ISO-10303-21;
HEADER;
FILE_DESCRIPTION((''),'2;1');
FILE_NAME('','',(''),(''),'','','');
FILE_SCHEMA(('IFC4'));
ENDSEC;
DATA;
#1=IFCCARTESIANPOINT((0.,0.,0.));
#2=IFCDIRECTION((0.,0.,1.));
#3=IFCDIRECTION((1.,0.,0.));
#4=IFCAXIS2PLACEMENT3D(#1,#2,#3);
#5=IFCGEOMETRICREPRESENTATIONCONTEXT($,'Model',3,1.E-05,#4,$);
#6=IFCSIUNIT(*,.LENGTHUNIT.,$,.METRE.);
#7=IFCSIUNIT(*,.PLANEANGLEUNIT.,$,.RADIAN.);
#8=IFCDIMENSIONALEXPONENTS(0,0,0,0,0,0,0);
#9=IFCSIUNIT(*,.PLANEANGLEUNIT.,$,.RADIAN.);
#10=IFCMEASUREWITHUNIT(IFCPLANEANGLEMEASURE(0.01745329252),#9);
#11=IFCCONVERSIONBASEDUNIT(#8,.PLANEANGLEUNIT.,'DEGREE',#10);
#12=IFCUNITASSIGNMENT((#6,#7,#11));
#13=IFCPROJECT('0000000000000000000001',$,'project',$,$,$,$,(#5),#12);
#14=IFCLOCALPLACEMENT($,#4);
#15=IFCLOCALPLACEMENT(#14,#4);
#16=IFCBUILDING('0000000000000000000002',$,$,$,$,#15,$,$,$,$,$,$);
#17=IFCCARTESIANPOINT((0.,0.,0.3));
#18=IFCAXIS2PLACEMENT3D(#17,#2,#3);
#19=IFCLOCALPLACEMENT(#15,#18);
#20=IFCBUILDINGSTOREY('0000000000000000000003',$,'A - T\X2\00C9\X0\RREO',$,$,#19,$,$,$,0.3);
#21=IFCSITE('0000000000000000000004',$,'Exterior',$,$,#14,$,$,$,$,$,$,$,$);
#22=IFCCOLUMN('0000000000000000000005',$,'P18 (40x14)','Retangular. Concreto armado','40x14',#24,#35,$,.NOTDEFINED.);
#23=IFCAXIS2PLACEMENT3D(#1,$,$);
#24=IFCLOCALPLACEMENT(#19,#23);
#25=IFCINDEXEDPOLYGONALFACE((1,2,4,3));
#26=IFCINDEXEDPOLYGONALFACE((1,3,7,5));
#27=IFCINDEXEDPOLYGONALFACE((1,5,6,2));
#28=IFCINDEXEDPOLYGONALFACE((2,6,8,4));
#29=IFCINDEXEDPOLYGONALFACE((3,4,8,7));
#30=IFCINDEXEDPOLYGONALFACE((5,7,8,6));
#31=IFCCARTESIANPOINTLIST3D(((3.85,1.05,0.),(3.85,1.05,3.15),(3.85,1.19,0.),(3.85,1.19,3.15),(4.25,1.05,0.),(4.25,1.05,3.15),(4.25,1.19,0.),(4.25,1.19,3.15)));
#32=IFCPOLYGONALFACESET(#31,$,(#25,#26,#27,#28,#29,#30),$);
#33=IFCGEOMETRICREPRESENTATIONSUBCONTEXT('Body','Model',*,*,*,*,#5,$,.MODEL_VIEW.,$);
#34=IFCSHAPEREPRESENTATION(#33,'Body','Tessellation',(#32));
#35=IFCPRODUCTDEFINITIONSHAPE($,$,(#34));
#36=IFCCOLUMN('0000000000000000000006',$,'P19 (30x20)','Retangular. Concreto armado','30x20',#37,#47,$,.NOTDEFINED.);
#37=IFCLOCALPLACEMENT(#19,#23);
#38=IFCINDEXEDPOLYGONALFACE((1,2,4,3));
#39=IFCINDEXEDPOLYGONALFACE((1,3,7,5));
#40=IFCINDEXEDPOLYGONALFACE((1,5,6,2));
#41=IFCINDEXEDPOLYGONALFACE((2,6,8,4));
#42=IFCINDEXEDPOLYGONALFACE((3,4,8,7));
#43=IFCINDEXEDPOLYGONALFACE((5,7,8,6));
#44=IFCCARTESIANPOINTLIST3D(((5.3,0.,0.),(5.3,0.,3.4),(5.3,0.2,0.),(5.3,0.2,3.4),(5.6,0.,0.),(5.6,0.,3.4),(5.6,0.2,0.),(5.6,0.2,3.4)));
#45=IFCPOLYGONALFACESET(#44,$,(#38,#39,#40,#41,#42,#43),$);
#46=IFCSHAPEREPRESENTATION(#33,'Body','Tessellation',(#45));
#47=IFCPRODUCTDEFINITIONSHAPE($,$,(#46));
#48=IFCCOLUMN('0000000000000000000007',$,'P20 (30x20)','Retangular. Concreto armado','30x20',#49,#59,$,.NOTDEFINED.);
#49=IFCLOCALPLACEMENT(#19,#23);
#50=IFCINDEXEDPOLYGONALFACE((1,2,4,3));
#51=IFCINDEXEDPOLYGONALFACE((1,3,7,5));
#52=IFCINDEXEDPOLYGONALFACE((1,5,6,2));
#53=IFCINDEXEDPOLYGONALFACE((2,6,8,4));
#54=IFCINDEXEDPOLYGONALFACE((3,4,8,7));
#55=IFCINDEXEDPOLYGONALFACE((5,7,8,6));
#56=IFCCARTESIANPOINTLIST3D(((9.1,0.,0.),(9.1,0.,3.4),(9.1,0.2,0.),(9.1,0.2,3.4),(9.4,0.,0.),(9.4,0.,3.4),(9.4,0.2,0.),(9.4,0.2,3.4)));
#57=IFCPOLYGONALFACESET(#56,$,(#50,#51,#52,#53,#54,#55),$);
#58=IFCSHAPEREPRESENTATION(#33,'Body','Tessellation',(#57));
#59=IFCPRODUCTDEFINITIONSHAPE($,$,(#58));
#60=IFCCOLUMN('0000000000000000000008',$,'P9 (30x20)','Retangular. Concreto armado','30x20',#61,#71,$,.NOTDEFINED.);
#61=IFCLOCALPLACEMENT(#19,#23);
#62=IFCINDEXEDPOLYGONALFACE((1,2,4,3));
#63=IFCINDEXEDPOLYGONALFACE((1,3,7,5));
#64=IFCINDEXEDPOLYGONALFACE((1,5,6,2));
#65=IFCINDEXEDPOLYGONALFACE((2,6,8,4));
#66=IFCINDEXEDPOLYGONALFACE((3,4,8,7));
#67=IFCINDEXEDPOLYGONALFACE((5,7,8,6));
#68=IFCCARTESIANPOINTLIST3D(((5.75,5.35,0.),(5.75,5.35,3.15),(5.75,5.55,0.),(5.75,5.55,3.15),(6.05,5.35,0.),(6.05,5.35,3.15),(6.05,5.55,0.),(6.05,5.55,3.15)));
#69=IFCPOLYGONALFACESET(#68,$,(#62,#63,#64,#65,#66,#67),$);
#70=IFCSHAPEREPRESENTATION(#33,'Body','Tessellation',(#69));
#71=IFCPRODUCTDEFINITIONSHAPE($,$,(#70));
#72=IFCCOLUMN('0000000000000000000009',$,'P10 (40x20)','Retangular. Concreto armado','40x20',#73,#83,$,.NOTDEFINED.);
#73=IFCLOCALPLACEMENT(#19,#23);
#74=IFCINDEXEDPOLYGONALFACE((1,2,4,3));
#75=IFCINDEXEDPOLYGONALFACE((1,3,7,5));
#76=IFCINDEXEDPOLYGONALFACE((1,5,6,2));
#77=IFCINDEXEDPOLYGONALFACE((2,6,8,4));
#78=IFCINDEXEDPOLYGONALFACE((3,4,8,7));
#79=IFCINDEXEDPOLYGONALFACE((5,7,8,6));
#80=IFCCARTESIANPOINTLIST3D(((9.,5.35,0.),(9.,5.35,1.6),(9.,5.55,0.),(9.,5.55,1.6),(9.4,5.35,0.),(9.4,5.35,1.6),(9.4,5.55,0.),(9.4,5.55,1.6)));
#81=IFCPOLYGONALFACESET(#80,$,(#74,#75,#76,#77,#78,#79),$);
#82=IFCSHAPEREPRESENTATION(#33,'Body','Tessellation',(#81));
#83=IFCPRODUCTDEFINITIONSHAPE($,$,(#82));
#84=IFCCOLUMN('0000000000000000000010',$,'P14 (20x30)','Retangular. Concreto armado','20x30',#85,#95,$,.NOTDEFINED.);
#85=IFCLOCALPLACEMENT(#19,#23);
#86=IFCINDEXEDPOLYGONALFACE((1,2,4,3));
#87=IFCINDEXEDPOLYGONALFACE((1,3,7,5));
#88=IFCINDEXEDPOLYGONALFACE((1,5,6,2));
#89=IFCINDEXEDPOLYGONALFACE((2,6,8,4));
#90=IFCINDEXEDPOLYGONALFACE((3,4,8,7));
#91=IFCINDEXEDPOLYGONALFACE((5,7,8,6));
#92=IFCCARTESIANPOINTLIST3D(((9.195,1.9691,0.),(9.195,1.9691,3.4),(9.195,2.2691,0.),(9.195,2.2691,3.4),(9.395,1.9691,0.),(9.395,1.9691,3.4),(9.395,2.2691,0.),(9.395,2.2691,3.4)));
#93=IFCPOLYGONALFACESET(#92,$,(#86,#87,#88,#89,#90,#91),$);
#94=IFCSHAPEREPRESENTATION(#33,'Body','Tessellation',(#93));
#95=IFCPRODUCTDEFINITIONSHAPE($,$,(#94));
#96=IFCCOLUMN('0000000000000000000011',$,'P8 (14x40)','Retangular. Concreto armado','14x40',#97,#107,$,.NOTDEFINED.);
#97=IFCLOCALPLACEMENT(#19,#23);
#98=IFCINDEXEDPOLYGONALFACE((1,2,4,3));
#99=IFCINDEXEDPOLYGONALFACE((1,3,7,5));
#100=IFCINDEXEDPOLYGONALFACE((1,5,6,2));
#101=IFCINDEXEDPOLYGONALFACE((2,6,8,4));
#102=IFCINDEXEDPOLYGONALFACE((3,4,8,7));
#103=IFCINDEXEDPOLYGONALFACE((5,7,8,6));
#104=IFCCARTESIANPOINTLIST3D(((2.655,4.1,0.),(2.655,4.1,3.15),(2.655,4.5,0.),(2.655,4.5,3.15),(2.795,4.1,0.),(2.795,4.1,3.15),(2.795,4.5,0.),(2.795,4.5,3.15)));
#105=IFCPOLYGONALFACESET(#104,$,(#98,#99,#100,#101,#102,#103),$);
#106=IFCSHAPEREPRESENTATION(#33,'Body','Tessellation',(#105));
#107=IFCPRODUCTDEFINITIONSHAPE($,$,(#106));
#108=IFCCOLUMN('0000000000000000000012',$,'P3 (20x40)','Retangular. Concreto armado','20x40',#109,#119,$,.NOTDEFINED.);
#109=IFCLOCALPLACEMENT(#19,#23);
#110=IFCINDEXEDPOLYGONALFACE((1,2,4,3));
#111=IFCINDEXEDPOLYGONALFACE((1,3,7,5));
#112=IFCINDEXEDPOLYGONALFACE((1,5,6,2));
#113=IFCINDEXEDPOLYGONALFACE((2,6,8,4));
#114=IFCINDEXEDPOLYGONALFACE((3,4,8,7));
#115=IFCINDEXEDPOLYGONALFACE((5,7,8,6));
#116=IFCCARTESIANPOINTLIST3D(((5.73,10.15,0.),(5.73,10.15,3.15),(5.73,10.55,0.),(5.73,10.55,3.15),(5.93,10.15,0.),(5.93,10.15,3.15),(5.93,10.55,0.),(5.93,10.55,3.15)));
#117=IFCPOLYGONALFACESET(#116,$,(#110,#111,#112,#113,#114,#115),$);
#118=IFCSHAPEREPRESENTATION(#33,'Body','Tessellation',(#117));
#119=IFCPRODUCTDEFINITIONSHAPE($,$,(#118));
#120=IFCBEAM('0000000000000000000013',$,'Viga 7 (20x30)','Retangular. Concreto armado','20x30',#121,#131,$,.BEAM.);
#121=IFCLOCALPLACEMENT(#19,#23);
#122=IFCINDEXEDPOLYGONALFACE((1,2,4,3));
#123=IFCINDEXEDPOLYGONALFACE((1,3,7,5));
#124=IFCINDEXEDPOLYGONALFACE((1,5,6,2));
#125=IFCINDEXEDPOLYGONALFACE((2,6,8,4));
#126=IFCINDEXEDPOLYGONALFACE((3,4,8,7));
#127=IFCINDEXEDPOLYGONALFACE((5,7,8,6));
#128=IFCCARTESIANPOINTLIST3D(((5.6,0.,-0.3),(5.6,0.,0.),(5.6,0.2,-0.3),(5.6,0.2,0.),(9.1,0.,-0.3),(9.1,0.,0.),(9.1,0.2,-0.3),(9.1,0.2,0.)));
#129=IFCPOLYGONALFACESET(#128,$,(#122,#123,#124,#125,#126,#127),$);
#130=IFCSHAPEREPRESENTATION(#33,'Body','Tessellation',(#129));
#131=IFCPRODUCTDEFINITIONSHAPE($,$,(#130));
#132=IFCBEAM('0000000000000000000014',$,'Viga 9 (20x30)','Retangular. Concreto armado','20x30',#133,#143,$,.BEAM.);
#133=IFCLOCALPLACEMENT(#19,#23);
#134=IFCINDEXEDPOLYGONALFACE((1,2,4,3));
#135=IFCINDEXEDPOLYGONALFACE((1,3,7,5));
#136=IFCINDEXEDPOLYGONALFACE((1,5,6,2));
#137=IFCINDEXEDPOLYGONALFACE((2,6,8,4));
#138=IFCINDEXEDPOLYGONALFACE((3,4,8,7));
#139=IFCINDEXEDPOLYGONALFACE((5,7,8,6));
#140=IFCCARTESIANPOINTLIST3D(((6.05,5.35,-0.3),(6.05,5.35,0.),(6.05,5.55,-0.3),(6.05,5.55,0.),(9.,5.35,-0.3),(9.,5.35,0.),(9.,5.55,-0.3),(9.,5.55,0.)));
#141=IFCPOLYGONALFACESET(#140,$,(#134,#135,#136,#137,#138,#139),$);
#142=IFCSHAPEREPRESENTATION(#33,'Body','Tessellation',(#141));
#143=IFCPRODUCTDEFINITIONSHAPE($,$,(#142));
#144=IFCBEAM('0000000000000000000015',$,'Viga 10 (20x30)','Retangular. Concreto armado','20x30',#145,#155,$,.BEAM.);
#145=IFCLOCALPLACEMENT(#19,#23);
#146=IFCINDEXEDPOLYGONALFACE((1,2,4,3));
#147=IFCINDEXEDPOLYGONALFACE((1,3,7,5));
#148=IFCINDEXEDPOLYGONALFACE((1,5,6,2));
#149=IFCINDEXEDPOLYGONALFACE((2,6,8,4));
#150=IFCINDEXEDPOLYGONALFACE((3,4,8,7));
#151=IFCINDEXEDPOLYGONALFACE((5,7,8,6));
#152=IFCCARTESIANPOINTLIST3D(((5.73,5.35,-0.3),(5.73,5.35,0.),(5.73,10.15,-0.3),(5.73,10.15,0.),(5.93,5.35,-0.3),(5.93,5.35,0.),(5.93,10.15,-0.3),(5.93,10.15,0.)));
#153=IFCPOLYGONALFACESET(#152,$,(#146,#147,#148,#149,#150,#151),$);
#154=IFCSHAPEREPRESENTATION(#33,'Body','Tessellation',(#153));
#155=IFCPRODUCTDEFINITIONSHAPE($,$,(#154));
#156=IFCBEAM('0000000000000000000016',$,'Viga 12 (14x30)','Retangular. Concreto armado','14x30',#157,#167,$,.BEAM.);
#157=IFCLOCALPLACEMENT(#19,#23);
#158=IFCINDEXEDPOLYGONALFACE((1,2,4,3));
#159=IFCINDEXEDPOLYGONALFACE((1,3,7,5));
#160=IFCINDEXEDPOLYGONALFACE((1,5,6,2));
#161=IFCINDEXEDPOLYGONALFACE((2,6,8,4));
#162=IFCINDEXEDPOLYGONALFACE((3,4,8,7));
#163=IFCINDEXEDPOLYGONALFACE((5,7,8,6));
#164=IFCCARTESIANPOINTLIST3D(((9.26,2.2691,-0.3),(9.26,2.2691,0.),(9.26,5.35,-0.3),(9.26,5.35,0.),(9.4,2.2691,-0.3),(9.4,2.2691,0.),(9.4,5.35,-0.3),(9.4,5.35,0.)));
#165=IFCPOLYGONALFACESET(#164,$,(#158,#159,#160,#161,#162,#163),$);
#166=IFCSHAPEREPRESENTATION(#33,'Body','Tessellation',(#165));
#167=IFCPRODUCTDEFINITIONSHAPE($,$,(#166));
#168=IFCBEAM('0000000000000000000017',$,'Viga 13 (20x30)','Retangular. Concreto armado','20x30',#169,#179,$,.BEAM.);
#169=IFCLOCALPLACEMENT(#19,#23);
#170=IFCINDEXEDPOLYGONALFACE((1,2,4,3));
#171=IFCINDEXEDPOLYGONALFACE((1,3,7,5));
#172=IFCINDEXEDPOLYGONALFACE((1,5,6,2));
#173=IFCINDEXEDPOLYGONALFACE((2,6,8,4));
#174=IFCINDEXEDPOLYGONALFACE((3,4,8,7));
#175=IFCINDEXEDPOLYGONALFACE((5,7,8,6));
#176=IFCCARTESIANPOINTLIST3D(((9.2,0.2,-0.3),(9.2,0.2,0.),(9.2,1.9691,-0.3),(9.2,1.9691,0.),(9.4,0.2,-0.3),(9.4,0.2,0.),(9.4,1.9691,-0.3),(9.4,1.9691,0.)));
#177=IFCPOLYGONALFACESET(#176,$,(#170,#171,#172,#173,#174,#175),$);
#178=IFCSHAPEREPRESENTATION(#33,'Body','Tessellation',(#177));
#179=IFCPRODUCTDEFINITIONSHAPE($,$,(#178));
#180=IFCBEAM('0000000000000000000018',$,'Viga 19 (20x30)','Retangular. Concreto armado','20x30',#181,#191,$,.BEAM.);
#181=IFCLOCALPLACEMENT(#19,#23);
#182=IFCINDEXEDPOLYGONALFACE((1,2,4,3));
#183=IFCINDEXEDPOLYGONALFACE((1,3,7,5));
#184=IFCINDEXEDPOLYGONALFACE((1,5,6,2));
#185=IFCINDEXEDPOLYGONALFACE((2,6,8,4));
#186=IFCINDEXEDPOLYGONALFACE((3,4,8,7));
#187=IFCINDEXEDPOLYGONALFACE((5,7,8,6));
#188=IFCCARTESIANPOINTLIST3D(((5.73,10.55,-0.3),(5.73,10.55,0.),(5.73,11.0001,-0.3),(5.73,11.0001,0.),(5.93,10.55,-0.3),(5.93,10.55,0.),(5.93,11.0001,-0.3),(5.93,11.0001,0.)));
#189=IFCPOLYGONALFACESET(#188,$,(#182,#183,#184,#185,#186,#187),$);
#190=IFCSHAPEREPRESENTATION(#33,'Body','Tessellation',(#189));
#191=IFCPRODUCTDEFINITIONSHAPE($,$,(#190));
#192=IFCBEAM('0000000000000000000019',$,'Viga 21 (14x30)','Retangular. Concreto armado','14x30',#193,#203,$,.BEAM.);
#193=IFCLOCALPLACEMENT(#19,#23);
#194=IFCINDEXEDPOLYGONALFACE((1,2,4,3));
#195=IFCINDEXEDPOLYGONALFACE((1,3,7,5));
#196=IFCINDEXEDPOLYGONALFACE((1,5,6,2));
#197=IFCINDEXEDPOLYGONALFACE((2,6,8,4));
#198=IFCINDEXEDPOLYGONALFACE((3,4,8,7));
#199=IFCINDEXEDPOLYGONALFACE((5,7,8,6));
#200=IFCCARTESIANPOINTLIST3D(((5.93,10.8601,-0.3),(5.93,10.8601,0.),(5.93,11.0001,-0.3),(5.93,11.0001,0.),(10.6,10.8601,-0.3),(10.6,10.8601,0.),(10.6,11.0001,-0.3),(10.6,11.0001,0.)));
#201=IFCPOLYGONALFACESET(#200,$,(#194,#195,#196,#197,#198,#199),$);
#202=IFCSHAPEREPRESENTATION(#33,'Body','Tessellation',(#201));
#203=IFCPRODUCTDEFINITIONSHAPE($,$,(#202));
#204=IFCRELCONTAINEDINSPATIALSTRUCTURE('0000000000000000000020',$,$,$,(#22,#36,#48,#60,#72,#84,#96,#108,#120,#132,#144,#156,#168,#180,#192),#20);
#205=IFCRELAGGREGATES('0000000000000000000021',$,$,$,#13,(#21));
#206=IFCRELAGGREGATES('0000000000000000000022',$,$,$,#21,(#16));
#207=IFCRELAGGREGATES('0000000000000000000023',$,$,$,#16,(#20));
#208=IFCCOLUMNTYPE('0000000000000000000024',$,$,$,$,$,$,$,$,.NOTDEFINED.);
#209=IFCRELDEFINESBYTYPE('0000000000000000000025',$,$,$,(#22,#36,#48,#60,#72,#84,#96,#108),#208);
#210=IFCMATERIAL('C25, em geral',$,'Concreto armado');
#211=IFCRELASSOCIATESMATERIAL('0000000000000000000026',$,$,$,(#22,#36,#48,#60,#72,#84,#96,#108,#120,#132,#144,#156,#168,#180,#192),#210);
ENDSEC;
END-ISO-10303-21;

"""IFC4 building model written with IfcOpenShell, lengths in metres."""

from ifc_helpers import new_model, entity, si_unit, converted_unit, frame, frame_2d, origin_with_axes, origin_2d_with_axis, place, context, subcontext, project, spatial, rectangle, extrude, material, type_object, element, save


model = new_model("IFC4")

# Units and contexts
model_context = context("Model", 3, precision=1e-05, world=origin_with_axes())
body_context = subcontext(model_context, "Body", "Model", "MODEL_VIEW")
ifc_project = project(units=[si_unit("LENGTHUNIT", "METRE"), si_unit("PLANEANGLEUNIT", "RADIAN"), converted_unit("PLANEANGLEUNIT", "DEGREE", entity("IfcPlaneAngleMeasure", 0.01745329252), si_unit("PLANEANGLEUNIT", "RADIAN"), dimensions=[0, 0, 0, 0, 0, 0, 0])], contexts=[model_context])

# Site, building, storey
site_placement = place(None, origin_with_axes())
site = spatial("IfcSite", under=ifc_project, at=site_placement, Name="Exterior")
building_placement = place(site_placement, origin_with_axes())
building = spatial("IfcBuilding", under=site, at=building_placement)
storey_placement = place(building_placement, frame((0.0, 0.0, 0.3), z_axis=(0.0, 0.0, 1.0), x_axis=(1.0, 0.0, 0.0)))
storey = spatial("IfcBuildingStorey", under=building, at=storey_placement, Name="A - TÉRREO", Elevation=0.3)

# Columns
ifc_material = material(Name="C25, em geral", Category="Concreto armado")
column_type = type_object("IfcColumnType", PredefinedType="NOTDEFINED")
column_1_placement = place(storey_placement, frame((4.25, 1.12, 0.0), z_axis=(0.0, 0.0, 1.0), x_axis=(1.0, 0.0, 0.0)))
element("IfcColumn", 1, at=column_1_placement, inside=storey, type_object=column_type, material=ifc_material, Name="P18 (40x14)", Description="Retangular. Concreto armado", ObjectType="40x14", PredefinedType="NOTDEFINED", context=body_context, shape_type="SweptSolid", body=[
    extrude(rectangle(XDim=0.4, YDim=0.14, at=frame_2d((-0.2, 0.0), x_axis=(1.0, 0.0))), origin_with_axes(), (0.0, 0.0, 1.0), 3.15),
])
for number, where, z_axis, x_axis, name in (
    (2, (5.45, 0.1, 0.0), (0.0, 0.0, 1.0), (1.0, 0.0, 0.0), "P19 (30x20)"),
    (3, (9.25, 0.1, 0.0), (0.0, 0.0, 1.0), (1.0, 0.0, 0.0), "P20 (30x20)"),
):
    element("IfcColumn", number, at=place(storey_placement, frame(where, z_axis=z_axis, x_axis=x_axis)), inside=storey, type_object=column_type, material=ifc_material, Name=name, Description="Retangular. Concreto armado", ObjectType="30x20", PredefinedType="NOTDEFINED", context=body_context, shape_type="SweptSolid", body=[
        extrude(rectangle(XDim=0.3, YDim=0.2, at=origin_2d_with_axis()), origin_with_axes(), (0.0, 0.0, 1.0), 3.4),
    ])
column_2_placement = place(storey_placement, frame((5.9, 5.45, 0.0), z_axis=(0.0, 0.0, 1.0), x_axis=(1.0, 0.0, 0.0)))
element("IfcColumn", 4, at=column_2_placement, inside=storey, type_object=column_type, material=ifc_material, Name="P9 (30x20)", Description="Retangular. Concreto armado", ObjectType="30x20", PredefinedType="NOTDEFINED", context=body_context, shape_type="SweptSolid", body=[
    extrude(rectangle(XDim=0.3, YDim=0.2, at=origin_2d_with_axis()), origin_with_axes(), (0.0, 0.0, 1.0), 3.15),
])
column_3_placement = place(storey_placement, frame((9.2, 5.45, 0.0), z_axis=(0.0, 0.0, 1.0), x_axis=(1.0, 0.0, 0.0)))
element("IfcColumn", 5, at=column_3_placement, inside=storey, type_object=column_type, material=ifc_material, Name="P10 (40x20)", Description="Retangular. Concreto armado", ObjectType="40x20", PredefinedType="NOTDEFINED", context=body_context, shape_type="SweptSolid", body=[
    extrude(rectangle(XDim=0.4, YDim=0.2, at=origin_2d_with_axis()), origin_with_axes(), (0.0, 0.0, 1.0), 1.6),
])
column_4_placement = place(storey_placement, frame((9.295, 2.1191, 0.0), z_axis=(0.0, 0.0, 1.0), x_axis=(1.0, 0.0, 0.0)))
element("IfcColumn", 6, at=column_4_placement, inside=storey, type_object=column_type, material=ifc_material, Name="P14 (20x30)", Description="Retangular. Concreto armado", ObjectType="20x30", PredefinedType="NOTDEFINED", context=body_context, shape_type="SweptSolid", body=[
    extrude(rectangle(XDim=0.2, YDim=0.3, at=origin_2d_with_axis()), origin_with_axes(), (0.0, 0.0, 1.0), 3.4),
])
column_5_placement = place(storey_placement, frame((2.725, 4.5, 0.0), z_axis=(0.0, 0.0, 1.0), x_axis=(1.0, 0.0, 0.0)))
element("IfcColumn", 7, at=column_5_placement, inside=storey, type_object=column_type, material=ifc_material, Name="P8 (14x40)", Description="Retangular. Concreto armado", ObjectType="14x40", PredefinedType="NOTDEFINED", context=body_context, shape_type="SweptSolid", body=[
    extrude(rectangle(XDim=0.14, YDim=0.4, at=frame_2d((0.0, -0.2), x_axis=(1.0, 0.0))), origin_with_axes(), (0.0, 0.0, 1.0), 3.15),
])
column_6_placement = place(storey_placement, frame((5.83, 10.35, 0.0), z_axis=(0.0, 0.0, 1.0), x_axis=(1.0, 0.0, 0.0)))
element("IfcColumn", 8, at=column_6_placement, inside=storey, type_object=column_type, material=ifc_material, Name="P3 (20x40)", Description="Retangular. Concreto armado", ObjectType="20x40", PredefinedType="NOTDEFINED", context=body_context, shape_type="SweptSolid", body=[
    extrude(rectangle(XDim=0.2, YDim=0.4, at=origin_2d_with_axis()), origin_with_axes(), (0.0, 0.0, 1.0), 3.15),
])

# Beams
beam_1_placement = place(storey_placement, frame((9.1, 0.1, 0.0), z_axis=(-1.0, 0.0, 0.0), x_axis=(0.0, -1.0, 0.0)))
element("IfcBeam", 9, at=beam_1_placement, inside=storey, material=ifc_material, Name="Viga 7 (20x30)", Description="Retangular. Concreto armado", ObjectType="20x30", PredefinedType="BEAM", context=body_context, shape_type="SweptSolid", body=[
    extrude(rectangle(XDim=0.2, YDim=0.3, at=frame_2d((0.0, -0.15), x_axis=(1.0, 0.0))), origin_with_axes(), (0.0, 0.0, 1.0), 3.5),
])
beam_2_placement = place(storey_placement, frame((9.0, 5.45, 0.0), z_axis=(-1.0, 0.0, 0.0), x_axis=(0.0, -1.0, 0.0)))
element("IfcBeam", 10, at=beam_2_placement, inside=storey, material=ifc_material, Name="Viga 9 (20x30)", Description="Retangular. Concreto armado", ObjectType="20x30", PredefinedType="BEAM", context=body_context, shape_type="SweptSolid", body=[
    extrude(rectangle(XDim=0.2, YDim=0.3, at=frame_2d((0.0, -0.15), x_axis=(1.0, 0.0))), origin_with_axes(), (0.0, 0.0, 1.0), 2.95),
])
beam_3_placement = place(storey_placement, frame((5.83, 10.15, 0.0), z_axis=(0.0, -1.0, 0.0), x_axis=(1.0, 0.0, 0.0)))
element("IfcBeam", 11, at=beam_3_placement, inside=storey, material=ifc_material, Name="Viga 10 (20x30)", Description="Retangular. Concreto armado", ObjectType="20x30", PredefinedType="BEAM", context=body_context, shape_type="SweptSolid", body=[
    extrude(rectangle(XDim=0.2, YDim=0.3, at=frame_2d((0.0, -0.15), x_axis=(1.0, 0.0))), origin_with_axes(), (0.0, 0.0, 1.0), 4.8),
])
beam_4_placement = place(storey_placement, frame((9.33, 5.35, 0.0), z_axis=(0.0, -1.0, 0.0), x_axis=(1.0, 0.0, 0.0)))
element("IfcBeam", 12, at=beam_4_placement, inside=storey, material=ifc_material, Name="Viga 12 (14x30)", Description="Retangular. Concreto armado", ObjectType="14x30", PredefinedType="BEAM", context=body_context, shape_type="SweptSolid", body=[
    extrude(rectangle(XDim=0.14, YDim=0.3, at=frame_2d((0.0, -0.15), x_axis=(1.0, 0.0))), origin_with_axes(), (0.0, 0.0, 1.0), 3.0809),
])
beam_5_placement = place(storey_placement, frame((9.3, 1.9691, 0.0), z_axis=(0.0, -1.0, 0.0), x_axis=(1.0, 0.0, 0.0)))
element("IfcBeam", 13, at=beam_5_placement, inside=storey, material=ifc_material, Name="Viga 13 (20x30)", Description="Retangular. Concreto armado", ObjectType="20x30", PredefinedType="BEAM", context=body_context, shape_type="SweptSolid", body=[
    extrude(rectangle(XDim=0.2, YDim=0.3, at=frame_2d((0.0, -0.15), x_axis=(1.0, 0.0))), origin_with_axes(), (0.0, 0.0, 1.0), 1.7691),
])
beam_6_placement = place(storey_placement, frame((5.83, 10.55, 0.0), z_axis=(0.0, 1.0, 0.0), x_axis=(-1.0, 0.0, 0.0)))
element("IfcBeam", 14, at=beam_6_placement, inside=storey, material=ifc_material, Name="Viga 19 (20x30)", Description="Retangular. Concreto armado", ObjectType="20x30", PredefinedType="BEAM", context=body_context, shape_type="SweptSolid", body=[
    extrude(rectangle(XDim=0.2, YDim=0.3, at=frame_2d((0.0, -0.15), x_axis=(1.0, 0.0))), origin_with_axes(), (0.0, 0.0, 1.0), 0.4501),
])
beam_7_placement = place(storey_placement, frame((5.93, 10.9301, 0.0), z_axis=(1.0, 0.0, 0.0), x_axis=(0.0, 1.0, 0.0)))
element("IfcBeam", 15, at=beam_7_placement, inside=storey, material=ifc_material, Name="Viga 21 (14x30)", Description="Retangular. Concreto armado", ObjectType="14x30", PredefinedType="BEAM", context=body_context, shape_type="SweptSolid", body=[
    extrude(rectangle(XDim=0.14, YDim=0.3, at=frame_2d((0.0, -0.15), x_axis=(1.0, 0.0))), origin_with_axes(), (0.0, 0.0, 1.0), 4.67),
])

save(model, "model.ifc")
